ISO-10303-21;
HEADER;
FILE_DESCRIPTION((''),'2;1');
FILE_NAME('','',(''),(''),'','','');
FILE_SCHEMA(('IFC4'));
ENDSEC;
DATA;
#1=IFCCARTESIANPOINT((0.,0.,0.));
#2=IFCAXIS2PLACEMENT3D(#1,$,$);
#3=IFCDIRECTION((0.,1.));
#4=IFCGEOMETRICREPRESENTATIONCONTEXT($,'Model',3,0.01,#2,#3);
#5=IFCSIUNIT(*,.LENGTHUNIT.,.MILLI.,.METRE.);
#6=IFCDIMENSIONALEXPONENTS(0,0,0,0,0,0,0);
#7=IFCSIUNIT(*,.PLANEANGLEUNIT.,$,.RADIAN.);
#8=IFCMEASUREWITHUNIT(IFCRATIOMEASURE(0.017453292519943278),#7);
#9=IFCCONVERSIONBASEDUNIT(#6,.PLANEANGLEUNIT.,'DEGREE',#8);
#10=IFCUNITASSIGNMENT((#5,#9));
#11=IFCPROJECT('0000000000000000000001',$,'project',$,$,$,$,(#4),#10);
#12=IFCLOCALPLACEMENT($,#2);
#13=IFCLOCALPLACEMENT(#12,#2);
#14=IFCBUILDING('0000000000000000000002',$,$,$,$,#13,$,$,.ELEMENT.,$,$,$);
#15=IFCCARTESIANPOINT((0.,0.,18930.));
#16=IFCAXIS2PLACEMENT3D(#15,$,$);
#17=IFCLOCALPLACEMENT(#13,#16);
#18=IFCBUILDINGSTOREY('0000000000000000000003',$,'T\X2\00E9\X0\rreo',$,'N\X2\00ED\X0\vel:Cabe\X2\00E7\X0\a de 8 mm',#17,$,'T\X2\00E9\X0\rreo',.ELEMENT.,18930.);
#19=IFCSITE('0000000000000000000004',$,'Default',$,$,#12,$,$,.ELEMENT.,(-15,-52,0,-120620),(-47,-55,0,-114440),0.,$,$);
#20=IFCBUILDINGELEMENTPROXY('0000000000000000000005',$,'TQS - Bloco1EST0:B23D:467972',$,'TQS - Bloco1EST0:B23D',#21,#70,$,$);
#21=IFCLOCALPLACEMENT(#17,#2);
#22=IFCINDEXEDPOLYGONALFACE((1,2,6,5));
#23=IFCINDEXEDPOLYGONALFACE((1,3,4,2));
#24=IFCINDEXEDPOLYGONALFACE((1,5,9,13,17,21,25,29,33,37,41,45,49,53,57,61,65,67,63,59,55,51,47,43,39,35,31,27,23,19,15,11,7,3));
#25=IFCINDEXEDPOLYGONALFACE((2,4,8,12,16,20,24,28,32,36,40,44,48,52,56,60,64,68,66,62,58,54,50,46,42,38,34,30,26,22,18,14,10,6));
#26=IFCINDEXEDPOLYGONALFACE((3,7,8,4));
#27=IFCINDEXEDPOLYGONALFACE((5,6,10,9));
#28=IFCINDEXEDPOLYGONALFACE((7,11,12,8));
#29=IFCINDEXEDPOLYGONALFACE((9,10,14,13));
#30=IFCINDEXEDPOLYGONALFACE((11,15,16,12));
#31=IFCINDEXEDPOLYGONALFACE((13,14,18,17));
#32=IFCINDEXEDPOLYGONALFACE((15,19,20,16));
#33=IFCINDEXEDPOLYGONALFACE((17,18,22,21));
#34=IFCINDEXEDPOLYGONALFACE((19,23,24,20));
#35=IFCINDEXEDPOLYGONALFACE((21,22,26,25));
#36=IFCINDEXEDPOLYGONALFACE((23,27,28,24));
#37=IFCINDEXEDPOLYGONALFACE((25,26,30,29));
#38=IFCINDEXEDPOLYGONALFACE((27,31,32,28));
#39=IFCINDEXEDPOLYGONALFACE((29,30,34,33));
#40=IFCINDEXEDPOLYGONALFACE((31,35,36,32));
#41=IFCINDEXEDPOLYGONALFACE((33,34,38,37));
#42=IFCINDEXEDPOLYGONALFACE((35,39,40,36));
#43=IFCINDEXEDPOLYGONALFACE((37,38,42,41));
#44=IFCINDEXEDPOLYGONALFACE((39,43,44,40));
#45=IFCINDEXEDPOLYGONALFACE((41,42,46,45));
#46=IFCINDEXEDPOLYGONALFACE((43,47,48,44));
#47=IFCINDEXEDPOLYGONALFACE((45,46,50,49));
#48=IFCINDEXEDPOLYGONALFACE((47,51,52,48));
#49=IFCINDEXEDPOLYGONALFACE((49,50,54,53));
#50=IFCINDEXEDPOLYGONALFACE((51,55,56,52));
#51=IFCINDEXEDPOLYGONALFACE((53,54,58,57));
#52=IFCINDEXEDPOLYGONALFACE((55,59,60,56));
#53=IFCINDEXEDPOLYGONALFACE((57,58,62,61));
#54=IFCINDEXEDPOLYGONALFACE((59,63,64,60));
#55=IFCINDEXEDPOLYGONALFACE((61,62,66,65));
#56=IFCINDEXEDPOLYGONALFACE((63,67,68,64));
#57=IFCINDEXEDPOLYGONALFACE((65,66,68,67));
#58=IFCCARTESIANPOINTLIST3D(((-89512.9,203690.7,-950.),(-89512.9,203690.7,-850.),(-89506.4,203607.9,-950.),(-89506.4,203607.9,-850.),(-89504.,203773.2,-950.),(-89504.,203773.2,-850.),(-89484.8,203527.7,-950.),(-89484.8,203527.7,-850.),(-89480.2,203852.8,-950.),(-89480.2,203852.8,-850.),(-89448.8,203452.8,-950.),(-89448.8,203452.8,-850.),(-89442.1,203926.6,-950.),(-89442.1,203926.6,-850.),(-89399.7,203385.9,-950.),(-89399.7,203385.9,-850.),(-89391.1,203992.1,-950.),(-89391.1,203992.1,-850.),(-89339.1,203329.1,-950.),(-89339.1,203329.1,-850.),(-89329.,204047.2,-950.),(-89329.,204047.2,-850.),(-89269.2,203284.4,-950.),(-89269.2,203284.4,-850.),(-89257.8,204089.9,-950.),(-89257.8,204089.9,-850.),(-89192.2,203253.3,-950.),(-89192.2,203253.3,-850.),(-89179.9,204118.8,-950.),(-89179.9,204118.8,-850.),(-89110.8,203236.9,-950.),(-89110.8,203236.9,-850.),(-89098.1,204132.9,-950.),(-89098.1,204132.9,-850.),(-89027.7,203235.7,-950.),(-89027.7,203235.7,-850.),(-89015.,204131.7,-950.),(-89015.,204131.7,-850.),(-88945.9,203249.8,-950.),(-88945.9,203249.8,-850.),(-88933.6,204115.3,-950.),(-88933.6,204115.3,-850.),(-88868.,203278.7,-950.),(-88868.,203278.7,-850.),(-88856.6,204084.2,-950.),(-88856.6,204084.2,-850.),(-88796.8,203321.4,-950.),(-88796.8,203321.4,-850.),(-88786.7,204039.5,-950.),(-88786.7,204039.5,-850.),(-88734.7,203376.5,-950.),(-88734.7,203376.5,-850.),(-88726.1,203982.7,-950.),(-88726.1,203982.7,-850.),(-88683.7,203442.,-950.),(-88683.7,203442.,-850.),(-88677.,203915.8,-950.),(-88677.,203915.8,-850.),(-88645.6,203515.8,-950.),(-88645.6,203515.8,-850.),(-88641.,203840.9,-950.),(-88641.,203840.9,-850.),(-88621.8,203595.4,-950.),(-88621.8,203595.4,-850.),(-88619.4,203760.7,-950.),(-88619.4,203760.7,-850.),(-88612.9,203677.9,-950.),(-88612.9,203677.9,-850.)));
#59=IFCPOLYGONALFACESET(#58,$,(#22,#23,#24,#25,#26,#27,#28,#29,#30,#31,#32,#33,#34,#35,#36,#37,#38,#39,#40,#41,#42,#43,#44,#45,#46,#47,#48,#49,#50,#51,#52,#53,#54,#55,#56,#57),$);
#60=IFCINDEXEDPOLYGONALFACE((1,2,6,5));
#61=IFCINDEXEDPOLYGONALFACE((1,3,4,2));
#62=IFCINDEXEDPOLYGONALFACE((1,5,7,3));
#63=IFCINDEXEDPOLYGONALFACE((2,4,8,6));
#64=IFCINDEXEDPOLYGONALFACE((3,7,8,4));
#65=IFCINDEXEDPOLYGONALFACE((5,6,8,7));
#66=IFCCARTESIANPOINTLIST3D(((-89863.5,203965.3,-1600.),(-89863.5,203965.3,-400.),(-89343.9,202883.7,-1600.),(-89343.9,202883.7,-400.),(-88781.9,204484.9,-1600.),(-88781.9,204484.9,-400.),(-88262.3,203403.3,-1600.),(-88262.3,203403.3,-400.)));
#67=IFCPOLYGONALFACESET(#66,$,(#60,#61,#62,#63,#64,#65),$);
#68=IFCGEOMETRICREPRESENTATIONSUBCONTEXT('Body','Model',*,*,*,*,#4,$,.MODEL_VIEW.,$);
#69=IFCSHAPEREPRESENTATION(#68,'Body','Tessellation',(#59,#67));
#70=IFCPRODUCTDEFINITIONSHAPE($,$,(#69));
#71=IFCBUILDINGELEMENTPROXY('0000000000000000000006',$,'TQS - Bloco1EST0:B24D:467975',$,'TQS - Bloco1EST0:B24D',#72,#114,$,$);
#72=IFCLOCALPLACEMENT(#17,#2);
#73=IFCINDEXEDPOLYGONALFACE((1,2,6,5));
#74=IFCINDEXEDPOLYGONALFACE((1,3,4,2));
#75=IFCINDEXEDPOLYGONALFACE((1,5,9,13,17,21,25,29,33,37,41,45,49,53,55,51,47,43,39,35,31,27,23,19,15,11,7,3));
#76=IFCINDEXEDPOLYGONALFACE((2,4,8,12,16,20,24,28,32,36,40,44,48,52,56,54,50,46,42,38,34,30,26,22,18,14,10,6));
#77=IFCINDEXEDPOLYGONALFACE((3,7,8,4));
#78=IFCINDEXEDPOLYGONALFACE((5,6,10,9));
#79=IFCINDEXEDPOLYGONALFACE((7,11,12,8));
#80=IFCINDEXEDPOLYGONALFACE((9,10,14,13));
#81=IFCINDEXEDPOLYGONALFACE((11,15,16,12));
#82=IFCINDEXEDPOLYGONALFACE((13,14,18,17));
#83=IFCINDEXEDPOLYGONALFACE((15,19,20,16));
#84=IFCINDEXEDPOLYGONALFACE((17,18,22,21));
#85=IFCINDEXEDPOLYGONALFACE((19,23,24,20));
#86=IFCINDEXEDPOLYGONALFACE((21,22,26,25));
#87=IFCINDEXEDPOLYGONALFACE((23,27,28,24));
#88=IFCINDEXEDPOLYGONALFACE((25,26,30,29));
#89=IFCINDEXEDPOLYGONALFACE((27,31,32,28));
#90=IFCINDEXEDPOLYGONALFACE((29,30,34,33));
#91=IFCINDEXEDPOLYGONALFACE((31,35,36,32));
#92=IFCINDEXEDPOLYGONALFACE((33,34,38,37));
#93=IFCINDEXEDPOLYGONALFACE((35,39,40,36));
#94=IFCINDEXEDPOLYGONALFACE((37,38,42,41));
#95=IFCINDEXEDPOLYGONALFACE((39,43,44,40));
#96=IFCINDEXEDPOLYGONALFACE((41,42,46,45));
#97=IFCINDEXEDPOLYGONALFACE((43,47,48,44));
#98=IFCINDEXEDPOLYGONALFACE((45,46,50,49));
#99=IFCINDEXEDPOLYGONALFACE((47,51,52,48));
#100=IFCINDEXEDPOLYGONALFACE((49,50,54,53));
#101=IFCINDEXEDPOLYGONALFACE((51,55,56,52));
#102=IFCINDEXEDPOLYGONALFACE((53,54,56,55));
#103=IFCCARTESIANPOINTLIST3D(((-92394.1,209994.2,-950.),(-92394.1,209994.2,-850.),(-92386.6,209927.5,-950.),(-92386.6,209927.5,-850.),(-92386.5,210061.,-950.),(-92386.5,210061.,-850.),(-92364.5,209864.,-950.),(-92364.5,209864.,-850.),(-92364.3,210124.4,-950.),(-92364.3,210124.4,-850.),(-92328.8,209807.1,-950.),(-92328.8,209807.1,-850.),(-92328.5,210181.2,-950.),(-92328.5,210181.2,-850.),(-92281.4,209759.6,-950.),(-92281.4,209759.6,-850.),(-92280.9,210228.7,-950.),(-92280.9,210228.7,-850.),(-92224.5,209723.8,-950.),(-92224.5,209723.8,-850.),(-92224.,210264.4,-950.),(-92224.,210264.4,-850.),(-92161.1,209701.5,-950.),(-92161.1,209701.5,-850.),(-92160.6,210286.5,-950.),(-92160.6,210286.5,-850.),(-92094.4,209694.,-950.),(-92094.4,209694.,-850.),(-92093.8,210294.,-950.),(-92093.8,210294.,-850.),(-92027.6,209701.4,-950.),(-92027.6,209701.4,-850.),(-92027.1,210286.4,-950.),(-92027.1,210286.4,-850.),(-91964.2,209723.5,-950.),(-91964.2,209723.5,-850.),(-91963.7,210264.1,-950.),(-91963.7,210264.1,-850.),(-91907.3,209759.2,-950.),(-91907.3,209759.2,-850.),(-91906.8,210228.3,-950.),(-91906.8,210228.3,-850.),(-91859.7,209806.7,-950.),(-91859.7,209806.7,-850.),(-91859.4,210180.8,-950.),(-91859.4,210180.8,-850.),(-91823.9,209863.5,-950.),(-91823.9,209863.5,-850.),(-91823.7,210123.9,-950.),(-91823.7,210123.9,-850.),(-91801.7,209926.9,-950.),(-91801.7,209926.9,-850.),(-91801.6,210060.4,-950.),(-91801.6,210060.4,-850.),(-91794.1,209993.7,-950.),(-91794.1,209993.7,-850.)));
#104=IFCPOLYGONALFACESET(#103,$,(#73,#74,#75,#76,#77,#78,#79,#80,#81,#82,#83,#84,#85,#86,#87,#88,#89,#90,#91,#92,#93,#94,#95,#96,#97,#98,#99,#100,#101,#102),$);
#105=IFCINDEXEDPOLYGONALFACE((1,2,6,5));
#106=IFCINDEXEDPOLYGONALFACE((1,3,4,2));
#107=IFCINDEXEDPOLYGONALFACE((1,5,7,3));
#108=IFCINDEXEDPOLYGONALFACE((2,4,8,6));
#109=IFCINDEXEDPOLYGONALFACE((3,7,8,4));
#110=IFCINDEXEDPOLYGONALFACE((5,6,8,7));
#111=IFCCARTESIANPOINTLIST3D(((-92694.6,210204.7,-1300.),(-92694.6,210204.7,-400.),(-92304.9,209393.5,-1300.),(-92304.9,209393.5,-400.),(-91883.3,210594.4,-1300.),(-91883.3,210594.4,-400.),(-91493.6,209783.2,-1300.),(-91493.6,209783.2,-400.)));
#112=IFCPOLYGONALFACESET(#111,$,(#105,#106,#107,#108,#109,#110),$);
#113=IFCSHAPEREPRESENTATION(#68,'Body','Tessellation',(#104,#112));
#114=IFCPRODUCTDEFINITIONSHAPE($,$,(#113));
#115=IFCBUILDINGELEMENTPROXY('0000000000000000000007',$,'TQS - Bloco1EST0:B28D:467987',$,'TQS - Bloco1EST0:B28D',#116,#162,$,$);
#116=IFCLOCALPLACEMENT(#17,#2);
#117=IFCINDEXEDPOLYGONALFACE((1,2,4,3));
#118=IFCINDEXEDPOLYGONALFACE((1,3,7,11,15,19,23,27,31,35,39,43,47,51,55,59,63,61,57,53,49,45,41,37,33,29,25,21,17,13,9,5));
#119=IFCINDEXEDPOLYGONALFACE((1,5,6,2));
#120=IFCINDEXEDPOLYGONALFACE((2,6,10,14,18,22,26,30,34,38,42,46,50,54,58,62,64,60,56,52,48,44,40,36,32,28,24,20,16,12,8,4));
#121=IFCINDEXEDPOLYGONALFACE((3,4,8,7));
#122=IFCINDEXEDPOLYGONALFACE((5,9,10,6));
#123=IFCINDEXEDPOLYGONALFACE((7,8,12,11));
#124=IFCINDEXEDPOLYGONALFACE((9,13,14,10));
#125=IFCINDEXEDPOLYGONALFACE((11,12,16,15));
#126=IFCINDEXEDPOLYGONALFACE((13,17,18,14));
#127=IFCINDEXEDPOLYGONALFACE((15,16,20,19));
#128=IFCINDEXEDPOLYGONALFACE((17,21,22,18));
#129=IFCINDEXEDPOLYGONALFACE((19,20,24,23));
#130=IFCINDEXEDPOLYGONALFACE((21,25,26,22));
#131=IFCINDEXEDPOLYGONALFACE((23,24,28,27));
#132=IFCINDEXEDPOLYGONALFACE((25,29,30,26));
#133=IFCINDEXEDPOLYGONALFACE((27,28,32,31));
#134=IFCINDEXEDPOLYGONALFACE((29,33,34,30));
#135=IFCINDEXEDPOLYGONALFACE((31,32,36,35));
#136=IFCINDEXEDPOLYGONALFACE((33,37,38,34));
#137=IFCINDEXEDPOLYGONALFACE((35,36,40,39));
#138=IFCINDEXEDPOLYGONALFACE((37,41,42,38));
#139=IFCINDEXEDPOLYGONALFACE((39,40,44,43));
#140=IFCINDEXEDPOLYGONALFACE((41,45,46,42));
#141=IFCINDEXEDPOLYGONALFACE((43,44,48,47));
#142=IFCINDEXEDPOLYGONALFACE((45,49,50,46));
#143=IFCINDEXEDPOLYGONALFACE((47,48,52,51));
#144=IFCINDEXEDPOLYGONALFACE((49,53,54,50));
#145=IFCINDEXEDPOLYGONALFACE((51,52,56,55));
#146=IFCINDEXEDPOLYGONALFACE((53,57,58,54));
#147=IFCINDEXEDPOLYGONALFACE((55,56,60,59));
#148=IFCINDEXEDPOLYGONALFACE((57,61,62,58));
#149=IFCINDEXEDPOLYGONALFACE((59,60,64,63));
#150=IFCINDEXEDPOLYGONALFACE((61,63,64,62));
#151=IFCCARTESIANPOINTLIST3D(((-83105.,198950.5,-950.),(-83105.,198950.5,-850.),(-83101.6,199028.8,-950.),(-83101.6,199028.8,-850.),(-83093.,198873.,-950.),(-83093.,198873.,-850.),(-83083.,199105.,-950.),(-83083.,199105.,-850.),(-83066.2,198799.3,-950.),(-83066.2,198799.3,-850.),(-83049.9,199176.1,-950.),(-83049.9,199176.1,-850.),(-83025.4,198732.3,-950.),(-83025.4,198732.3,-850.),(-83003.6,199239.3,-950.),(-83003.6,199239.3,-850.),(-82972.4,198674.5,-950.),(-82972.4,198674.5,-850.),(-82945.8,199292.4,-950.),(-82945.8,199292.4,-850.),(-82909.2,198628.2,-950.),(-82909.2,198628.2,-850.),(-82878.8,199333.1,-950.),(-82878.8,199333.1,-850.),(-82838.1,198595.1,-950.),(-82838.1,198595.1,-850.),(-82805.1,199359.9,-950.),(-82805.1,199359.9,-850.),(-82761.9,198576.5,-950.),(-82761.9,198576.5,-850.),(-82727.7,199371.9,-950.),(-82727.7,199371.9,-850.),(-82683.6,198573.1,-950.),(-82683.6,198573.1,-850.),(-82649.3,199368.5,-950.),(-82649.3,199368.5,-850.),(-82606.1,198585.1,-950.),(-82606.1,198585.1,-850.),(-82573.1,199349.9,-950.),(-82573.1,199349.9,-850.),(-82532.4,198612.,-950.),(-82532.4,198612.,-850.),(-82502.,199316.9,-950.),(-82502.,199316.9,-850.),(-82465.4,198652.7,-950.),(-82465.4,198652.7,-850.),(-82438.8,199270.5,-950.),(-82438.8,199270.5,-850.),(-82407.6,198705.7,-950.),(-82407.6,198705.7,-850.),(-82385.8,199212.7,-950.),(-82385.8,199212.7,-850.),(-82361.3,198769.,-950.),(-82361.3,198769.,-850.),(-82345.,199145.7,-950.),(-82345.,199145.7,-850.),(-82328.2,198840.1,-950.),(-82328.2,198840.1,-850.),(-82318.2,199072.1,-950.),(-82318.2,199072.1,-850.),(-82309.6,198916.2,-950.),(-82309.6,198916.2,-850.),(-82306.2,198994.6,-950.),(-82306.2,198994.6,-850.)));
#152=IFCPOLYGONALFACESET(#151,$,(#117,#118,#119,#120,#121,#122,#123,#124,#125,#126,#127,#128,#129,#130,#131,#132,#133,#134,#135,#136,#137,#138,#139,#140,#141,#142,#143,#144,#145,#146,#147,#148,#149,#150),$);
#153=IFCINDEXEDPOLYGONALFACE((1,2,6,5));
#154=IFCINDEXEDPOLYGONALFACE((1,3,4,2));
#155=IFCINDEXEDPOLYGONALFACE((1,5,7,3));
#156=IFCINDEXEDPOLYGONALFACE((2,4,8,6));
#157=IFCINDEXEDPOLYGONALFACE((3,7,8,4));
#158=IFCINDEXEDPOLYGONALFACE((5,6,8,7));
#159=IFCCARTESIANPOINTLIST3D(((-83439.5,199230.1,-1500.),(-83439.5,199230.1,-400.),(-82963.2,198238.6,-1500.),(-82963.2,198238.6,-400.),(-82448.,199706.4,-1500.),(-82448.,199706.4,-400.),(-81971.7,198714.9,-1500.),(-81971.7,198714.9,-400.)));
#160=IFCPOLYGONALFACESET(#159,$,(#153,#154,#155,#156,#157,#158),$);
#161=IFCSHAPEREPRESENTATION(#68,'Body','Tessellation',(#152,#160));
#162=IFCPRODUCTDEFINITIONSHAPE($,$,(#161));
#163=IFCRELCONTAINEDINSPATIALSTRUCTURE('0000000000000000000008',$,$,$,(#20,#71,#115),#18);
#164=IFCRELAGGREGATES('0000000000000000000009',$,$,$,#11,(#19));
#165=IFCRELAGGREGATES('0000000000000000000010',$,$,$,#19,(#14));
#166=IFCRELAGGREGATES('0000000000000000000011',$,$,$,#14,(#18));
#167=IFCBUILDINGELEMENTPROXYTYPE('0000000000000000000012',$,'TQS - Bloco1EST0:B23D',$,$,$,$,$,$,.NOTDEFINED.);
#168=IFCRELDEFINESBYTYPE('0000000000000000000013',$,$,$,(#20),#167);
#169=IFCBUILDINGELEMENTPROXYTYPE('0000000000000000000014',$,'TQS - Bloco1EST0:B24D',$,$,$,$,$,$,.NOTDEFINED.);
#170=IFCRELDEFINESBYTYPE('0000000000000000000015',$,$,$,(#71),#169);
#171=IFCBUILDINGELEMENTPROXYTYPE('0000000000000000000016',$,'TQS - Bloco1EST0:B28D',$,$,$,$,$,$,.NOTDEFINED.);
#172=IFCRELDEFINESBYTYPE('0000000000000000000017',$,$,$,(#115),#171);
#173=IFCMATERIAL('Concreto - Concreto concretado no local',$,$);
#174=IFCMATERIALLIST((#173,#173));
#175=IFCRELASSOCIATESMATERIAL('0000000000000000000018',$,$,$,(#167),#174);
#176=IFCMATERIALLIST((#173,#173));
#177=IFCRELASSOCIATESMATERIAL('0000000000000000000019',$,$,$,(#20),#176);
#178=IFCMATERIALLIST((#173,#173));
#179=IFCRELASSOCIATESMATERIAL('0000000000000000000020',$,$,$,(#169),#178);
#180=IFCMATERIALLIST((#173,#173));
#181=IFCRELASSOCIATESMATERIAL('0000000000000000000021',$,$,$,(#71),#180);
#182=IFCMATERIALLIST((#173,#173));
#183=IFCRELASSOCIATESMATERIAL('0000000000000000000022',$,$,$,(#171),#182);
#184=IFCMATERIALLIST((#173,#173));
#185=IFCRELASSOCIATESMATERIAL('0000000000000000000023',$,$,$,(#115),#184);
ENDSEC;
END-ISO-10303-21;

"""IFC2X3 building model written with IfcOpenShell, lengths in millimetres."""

from ifc_helpers import new_model, entity, si_unit, converted_unit, direction, frame, frame_2d, origin, origin_2d_with_axis, place, context, subcontext, project, spatial, rectangle, circle, extrude, source, transform, mapped, material, material_list, type_object, type_shapes, element, save


model = new_model("IFC2X3")

# Units and contexts
model_context = context("Model", 3, precision=0.01, world=origin(), true_north=direction((0.0, 1.0)))
body_context = subcontext(model_context, "Body", "Model", "MODEL_VIEW")
ifc_project = project(units=[si_unit("LENGTHUNIT", "METRE", prefix="MILLI"), converted_unit("PLANEANGLEUNIT", "DEGREE", entity("IfcRatioMeasure", 0.017453292519943278), si_unit("PLANEANGLEUNIT", "RADIAN"), dimensions=[0, 0, 0, 0, 0, 0, 0])], contexts=[model_context])

# Site, building, storey
site_placement = place(None, origin())
site = spatial("IfcSite", under=ifc_project, at=site_placement, Name="Default", CompositionType="ELEMENT", RefLatitude=(-15, -52, 0, -120620), RefLongitude=(-47, -55, 0, -114440), RefElevation=0.0)
building_placement = place(site_placement, origin())
building = spatial("IfcBuilding", under=site, at=building_placement, CompositionType="ELEMENT")
storey_placement = place(building_placement, frame((0.0, 0.0, 18930.0)))
storey = spatial("IfcBuildingStorey", under=building, at=storey_placement, Name="Térreo", ObjectType="Nível:Cabeça de 8 mm", LongName="Térreo", CompositionType="ELEMENT", Elevation=18930.0)

# Building element proxies
ifc_material_1 = material(Name="Concreto - Concreto concretado no local")
ifc_material_list_1 = material_list([ifc_material_1, ifc_material_1])
ifc_material_list_2 = material_list([ifc_material_1, ifc_material_1])
building_element_proxy_type_1 = type_object("IfcBuildingElementProxyType", Name="TQS - Bloco1EST0:B23D", PredefinedType="NOTDEFINED", material=ifc_material_list_2)
shared_shape_1 = source(origin(), body_context, "Body", "SweptSolid", [
    extrude(circle(Radius=450.0, at=frame_2d((0.0, 0.0), x_axis=(1.0, 0.0))), frame((0.0, 0.0, -550.0)), (0.0, 0.0, 1.0), 100.0),
    extrude(rectangle(XDim=1200.0, YDim=1200.0, at=origin_2d_with_axis()), frame((0.0, 0.0, -1200.0), z_axis=(0.0, 0.0, 1.0), x_axis=(-1.0, 0.0, 0.0)), (0.0, 0.0, 1.0), 1200.0),
])
type_shapes(building_element_proxy_type_1, [shared_shape_1])
proxy_1_placement = place(storey_placement, frame((-89062.9, 203684.3, -400.0), z_axis=(0.0, 0.0, 1.0), x_axis=(-0.43303, 0.90138, 0.0)))
element("IfcBuildingElementProxy", 1, at=proxy_1_placement, inside=storey, type_object=building_element_proxy_type_1, material=ifc_material_list_1, Name="TQS - Bloco1EST0:B23D:467972", ObjectType="TQS - Bloco1EST0:B23D", context=body_context, shape_type="MappedRepresentation", body=[
    mapped(shared_shape_1, transform((0.0, 0.0, 0.0), scale=1.0)),
])
ifc_material_list_3 = material_list([ifc_material_1, ifc_material_1])
ifc_material_list_4 = material_list([ifc_material_1, ifc_material_1])
building_element_proxy_type_2 = type_object("IfcBuildingElementProxyType", Name="TQS - Bloco1EST0:B24D", PredefinedType="NOTDEFINED", material=ifc_material_list_4)
shared_shape_2 = source(origin(), body_context, "Body", "SweptSolid", [
    extrude(circle(Radius=300.0, at=frame_2d((0.0, 0.0), x_axis=(1.0, 0.0))), frame((0.0, 0.0, -550.0)), (0.0, 0.0, 1.0), 100.0),
    extrude(rectangle(XDim=900.0, YDim=900.0, at=origin_2d_with_axis()), frame((0.0, 0.0, -900.0), z_axis=(0.0, 0.0, 1.0), x_axis=(-1.0, 0.0, 0.0)), (0.0, 0.0, 1.0), 900.0),
])
type_shapes(building_element_proxy_type_2, [shared_shape_2])
proxy_2_placement = place(storey_placement, frame((-92094.1, 209994.0, -400.0), z_axis=(0.0, 0.0, 1.0), x_axis=(-0.43303, 0.90138, 0.0)))
element("IfcBuildingElementProxy", 2, at=proxy_2_placement, inside=storey, type_object=building_element_proxy_type_2, material=ifc_material_list_3, Name="TQS - Bloco1EST0:B24D:467975", ObjectType="TQS - Bloco1EST0:B24D", context=body_context, shape_type="MappedRepresentation", body=[
    mapped(shared_shape_2, transform((0.0, 0.0, 0.0), scale=1.0)),
])
ifc_material_list_5 = material_list([ifc_material_1, ifc_material_1])
ifc_material_list_6 = material_list([ifc_material_1, ifc_material_1])
building_element_proxy_type_3 = type_object("IfcBuildingElementProxyType", Name="TQS - Bloco1EST0:B28D", PredefinedType="NOTDEFINED", material=ifc_material_list_6)
shared_shape_3 = source(origin(), body_context, "Body", "SweptSolid", [
    extrude(circle(Radius=400.0, at=frame_2d((0.0, 0.0), x_axis=(1.0, 0.0))), frame((0.0, 0.0, -550.0)), (0.0, 0.0, 1.0), 100.0),
    extrude(rectangle(XDim=1100.0, YDim=1100.0, at=origin_2d_with_axis()), frame((0.0, 0.0, -1100.0), z_axis=(0.0, 0.0, 1.0), x_axis=(-1.0, 0.0, 0.0)), (0.0, 0.0, 1.0), 1100.0),
])
type_shapes(building_element_proxy_type_3, [shared_shape_3])
proxy_3_placement = place(storey_placement, frame((-82705.6, 198972.5, -400.0), z_axis=(0.0, 0.0, 1.0), x_axis=(-0.43303, 0.90138, 0.0)))
element("IfcBuildingElementProxy", 3, at=proxy_3_placement, inside=storey, type_object=building_element_proxy_type_3, material=ifc_material_list_5, Name="TQS - Bloco1EST0:B28D:467987", ObjectType="TQS - Bloco1EST0:B28D", context=body_context, shape_type="MappedRepresentation", body=[
    mapped(shared_shape_3, transform((0.0, 0.0, 0.0), scale=1.0)),
])

save(model, "model.ifc")
